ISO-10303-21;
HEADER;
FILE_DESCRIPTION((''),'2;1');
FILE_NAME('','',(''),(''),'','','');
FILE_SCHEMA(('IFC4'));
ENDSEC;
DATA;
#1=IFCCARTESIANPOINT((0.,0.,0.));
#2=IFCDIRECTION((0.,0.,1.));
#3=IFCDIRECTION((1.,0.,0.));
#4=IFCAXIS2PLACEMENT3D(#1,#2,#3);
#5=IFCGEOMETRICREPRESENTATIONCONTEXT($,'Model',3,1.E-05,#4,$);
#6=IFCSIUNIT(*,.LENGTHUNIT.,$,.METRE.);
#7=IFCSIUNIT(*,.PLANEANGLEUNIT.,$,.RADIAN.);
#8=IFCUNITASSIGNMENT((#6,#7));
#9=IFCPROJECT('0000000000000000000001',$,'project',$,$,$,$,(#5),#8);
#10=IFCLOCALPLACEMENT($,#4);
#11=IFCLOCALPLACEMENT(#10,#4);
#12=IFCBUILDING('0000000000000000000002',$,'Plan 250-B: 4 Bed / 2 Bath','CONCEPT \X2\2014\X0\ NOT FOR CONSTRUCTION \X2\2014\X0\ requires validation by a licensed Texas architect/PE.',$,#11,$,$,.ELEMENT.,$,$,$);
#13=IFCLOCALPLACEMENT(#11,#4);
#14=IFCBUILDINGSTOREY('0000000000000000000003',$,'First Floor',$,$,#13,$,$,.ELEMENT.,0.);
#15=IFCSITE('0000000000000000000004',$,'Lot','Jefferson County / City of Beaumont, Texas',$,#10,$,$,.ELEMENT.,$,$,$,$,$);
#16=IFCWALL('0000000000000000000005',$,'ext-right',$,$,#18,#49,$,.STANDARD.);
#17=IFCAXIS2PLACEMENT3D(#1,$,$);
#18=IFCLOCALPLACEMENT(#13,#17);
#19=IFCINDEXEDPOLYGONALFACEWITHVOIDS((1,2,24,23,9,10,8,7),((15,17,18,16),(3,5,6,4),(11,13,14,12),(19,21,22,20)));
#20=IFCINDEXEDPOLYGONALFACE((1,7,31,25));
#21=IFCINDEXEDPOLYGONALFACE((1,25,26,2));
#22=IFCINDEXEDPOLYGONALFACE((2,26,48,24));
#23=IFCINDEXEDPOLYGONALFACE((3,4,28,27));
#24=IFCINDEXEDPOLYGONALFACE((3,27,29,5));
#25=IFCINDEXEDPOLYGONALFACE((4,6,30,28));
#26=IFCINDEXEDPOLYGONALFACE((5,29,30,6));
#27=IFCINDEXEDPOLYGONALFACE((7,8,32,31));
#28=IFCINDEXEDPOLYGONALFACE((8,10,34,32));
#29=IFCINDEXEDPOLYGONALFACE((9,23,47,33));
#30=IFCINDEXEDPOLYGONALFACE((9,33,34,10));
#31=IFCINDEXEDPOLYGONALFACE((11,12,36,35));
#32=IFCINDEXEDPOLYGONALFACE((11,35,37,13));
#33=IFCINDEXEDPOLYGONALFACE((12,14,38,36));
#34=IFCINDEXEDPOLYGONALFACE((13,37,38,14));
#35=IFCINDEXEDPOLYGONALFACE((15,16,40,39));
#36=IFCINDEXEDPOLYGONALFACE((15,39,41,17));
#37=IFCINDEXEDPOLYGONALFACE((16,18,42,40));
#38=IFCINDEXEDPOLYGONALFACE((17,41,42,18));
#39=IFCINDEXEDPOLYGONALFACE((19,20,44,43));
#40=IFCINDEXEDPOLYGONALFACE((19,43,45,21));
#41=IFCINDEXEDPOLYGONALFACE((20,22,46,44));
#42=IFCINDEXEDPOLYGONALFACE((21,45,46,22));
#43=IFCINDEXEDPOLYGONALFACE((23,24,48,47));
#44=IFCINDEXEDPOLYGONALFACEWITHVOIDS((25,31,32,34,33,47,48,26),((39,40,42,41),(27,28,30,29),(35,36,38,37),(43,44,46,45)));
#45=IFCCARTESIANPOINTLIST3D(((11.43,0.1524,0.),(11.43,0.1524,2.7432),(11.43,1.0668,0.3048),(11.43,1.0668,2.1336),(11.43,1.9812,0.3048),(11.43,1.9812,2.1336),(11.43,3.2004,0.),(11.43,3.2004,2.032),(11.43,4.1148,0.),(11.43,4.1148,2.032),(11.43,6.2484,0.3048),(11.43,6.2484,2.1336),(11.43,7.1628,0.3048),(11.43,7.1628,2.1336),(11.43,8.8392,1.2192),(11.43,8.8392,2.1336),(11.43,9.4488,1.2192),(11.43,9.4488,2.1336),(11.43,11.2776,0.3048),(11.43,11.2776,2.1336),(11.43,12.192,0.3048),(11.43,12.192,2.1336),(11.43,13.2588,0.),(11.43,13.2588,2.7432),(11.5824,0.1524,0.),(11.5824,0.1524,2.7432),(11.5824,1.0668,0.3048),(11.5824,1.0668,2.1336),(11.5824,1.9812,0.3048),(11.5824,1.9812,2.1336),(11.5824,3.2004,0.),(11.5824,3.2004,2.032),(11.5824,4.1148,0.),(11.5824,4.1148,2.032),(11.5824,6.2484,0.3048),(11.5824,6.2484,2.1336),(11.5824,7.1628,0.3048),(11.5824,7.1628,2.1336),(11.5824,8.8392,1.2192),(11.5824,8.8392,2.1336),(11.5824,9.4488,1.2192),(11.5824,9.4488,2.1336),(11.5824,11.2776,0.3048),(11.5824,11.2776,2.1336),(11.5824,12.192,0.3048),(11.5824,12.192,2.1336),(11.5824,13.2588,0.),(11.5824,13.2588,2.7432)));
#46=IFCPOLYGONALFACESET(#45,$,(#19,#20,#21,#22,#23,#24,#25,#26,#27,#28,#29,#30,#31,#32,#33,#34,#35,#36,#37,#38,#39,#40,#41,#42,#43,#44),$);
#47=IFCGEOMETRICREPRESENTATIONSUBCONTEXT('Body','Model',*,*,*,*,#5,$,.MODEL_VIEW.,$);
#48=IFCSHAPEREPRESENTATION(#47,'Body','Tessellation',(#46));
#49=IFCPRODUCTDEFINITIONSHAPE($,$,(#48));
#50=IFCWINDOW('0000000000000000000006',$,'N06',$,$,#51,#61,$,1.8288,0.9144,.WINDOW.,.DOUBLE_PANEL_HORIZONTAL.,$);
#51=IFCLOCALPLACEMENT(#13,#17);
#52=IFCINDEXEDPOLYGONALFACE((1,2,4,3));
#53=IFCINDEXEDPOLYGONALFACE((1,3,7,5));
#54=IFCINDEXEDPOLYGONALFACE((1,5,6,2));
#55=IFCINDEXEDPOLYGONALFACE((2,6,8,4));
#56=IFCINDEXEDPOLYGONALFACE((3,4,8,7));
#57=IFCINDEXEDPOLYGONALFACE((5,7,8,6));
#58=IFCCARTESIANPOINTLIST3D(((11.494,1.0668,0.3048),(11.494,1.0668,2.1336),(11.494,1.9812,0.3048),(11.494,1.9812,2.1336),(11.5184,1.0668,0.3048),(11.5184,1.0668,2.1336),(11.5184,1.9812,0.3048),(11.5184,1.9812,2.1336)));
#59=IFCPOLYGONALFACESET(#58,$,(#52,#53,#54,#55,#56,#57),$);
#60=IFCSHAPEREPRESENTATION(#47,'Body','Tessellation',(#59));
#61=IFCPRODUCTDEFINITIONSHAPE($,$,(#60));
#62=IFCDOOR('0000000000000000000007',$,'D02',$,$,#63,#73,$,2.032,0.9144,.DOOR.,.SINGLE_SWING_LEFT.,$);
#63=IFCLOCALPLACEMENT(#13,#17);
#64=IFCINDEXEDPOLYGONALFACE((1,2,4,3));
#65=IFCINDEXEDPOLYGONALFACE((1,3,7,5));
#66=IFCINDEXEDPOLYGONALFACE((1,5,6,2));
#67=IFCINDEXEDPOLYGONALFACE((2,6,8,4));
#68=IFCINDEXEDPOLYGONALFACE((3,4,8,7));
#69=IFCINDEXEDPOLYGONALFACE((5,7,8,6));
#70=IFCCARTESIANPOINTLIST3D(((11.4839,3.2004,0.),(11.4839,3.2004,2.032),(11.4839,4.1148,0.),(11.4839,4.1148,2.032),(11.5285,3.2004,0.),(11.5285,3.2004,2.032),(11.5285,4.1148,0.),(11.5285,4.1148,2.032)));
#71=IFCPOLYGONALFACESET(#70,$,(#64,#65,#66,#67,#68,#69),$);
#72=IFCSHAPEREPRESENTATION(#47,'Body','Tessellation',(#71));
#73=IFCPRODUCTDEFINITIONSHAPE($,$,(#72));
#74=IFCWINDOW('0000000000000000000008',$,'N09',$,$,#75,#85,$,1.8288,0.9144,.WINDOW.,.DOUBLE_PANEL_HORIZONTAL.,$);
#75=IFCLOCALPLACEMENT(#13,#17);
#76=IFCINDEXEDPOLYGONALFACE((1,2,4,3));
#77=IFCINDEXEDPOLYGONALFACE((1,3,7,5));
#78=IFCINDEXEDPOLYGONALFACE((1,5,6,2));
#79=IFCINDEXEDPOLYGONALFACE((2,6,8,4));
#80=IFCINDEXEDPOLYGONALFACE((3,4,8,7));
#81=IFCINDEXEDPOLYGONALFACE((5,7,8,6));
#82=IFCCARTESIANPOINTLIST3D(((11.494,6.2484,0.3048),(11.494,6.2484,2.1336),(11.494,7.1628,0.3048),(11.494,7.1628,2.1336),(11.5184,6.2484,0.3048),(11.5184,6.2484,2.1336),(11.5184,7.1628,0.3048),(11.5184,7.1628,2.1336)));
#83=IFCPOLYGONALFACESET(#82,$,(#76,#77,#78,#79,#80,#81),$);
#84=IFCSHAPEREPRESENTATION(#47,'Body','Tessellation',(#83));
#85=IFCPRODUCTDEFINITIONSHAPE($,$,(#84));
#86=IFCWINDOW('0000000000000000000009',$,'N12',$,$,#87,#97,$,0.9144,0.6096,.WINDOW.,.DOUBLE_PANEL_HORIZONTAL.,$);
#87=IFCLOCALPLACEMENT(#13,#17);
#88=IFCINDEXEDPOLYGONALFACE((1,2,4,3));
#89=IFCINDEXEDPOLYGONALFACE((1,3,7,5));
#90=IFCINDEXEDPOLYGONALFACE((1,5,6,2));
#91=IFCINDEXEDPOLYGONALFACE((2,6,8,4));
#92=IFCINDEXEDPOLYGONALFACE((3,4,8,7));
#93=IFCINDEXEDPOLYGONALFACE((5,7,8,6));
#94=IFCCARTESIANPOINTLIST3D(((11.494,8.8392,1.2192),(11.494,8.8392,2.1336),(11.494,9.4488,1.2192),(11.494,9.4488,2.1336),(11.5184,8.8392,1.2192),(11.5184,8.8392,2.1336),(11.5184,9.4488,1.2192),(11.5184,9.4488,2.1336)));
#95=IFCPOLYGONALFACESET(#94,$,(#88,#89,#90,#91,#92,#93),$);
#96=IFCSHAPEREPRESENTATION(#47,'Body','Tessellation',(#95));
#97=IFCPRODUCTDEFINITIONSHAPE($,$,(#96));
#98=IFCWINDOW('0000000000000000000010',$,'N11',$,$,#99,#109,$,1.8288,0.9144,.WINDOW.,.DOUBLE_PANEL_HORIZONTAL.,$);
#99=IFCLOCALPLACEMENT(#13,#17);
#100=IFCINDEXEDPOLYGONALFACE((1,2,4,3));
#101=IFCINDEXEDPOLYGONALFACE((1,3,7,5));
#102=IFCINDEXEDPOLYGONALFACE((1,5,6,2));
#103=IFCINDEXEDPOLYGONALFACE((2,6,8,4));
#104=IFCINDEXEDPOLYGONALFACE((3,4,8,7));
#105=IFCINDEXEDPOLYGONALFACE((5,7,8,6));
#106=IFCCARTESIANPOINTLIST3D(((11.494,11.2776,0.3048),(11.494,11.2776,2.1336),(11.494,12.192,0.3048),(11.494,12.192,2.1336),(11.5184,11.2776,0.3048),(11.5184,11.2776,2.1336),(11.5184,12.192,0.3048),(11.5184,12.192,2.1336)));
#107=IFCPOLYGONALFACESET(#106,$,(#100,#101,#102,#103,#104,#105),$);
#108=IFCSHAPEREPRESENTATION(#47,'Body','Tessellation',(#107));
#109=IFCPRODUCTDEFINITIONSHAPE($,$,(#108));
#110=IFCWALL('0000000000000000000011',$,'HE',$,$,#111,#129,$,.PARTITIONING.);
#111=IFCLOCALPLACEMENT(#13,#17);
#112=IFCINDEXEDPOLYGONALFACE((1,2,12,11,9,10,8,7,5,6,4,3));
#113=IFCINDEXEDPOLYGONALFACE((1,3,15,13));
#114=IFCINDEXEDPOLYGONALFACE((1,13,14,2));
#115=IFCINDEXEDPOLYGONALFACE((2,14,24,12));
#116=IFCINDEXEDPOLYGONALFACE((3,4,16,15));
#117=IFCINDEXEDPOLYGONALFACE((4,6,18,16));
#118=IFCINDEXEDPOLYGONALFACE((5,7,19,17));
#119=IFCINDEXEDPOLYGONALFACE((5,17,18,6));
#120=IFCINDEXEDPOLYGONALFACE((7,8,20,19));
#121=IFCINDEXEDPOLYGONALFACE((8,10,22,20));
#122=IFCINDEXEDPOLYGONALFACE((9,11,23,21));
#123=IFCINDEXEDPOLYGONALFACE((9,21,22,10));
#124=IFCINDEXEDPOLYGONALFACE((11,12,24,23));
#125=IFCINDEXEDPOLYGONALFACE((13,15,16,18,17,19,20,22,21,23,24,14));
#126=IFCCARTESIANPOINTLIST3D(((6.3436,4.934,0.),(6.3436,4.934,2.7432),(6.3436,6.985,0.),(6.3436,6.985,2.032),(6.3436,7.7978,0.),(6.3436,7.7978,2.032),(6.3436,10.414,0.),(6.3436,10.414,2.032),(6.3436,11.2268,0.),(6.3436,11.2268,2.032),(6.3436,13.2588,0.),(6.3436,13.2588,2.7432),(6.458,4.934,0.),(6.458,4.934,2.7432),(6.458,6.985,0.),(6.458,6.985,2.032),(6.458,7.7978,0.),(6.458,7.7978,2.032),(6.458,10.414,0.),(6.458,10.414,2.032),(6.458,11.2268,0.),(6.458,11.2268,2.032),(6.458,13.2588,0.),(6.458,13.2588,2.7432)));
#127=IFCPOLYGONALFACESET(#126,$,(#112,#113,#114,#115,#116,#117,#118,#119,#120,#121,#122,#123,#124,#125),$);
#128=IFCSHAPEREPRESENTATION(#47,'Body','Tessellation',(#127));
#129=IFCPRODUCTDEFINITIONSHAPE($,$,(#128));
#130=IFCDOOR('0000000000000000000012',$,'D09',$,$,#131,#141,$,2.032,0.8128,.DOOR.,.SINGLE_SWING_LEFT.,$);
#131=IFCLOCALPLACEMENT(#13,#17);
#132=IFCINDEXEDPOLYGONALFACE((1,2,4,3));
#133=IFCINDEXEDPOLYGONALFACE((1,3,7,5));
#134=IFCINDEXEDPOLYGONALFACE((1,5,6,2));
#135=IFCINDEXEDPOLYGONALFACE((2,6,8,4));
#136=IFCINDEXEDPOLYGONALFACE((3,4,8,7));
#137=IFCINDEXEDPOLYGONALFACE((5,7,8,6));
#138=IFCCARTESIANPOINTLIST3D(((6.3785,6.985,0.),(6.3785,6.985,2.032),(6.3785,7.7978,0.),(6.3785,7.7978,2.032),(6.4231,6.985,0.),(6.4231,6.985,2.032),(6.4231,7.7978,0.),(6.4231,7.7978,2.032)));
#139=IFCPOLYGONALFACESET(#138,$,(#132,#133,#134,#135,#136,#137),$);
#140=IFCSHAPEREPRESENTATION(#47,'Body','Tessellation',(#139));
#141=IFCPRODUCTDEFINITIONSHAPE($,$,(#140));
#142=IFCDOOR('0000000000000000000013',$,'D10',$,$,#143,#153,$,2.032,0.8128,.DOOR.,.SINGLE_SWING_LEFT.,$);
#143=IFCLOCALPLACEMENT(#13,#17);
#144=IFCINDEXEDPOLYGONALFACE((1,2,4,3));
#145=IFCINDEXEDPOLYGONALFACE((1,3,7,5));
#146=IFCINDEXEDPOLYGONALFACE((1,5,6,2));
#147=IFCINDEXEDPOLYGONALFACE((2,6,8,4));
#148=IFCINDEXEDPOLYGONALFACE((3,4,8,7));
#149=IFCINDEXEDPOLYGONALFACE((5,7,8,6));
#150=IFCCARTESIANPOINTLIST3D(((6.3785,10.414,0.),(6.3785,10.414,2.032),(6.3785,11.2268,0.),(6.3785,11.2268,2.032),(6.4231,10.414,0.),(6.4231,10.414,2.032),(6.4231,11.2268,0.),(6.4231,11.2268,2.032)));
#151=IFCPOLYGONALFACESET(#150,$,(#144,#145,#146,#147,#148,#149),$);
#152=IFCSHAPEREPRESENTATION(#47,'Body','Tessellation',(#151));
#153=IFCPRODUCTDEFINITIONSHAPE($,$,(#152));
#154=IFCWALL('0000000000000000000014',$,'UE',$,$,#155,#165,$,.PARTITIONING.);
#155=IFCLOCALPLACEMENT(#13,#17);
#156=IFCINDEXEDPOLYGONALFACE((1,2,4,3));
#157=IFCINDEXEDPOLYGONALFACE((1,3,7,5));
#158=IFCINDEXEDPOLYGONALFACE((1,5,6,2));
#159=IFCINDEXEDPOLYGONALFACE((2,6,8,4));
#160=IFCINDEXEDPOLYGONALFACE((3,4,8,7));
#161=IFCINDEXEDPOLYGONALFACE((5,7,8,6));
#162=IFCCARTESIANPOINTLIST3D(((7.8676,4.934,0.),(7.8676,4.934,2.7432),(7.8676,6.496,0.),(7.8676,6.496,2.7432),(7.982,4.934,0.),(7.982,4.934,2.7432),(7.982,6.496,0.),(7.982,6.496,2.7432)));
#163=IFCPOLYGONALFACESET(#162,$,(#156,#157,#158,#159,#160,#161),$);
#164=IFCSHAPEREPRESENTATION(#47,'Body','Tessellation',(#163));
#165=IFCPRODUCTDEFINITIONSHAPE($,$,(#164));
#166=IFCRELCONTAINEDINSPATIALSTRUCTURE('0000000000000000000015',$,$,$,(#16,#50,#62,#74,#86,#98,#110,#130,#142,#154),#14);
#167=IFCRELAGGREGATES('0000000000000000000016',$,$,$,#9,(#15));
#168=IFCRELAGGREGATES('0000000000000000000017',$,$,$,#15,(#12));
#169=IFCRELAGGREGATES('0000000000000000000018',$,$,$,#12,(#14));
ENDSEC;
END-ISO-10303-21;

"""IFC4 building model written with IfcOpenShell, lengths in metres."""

from ifc_helpers import new_model, si_unit, frame, frame_2d, origin_with_axes, place, context, subcontext, project, spatial, rectangle, extrude, element, fill, save


model = new_model("IFC4")

# Units and contexts
model_context = context("Model", 3, precision=1e-05, world=origin_with_axes())
body_context = subcontext(model_context, "Body", "Model", "MODEL_VIEW")
ifc_project = project(units=[si_unit("LENGTHUNIT", "METRE"), si_unit("PLANEANGLEUNIT", "RADIAN")], contexts=[model_context])

# Site, building, storey
site_placement = place(None, origin_with_axes())
site = spatial("IfcSite", under=ifc_project, at=site_placement, Name="Lot", Description="Jefferson County / City of Beaumont, Texas", CompositionType="ELEMENT")
building_placement = place(site_placement, origin_with_axes())
building = spatial("IfcBuilding", under=site, at=building_placement, Name="Plan 250-B: 4 Bed / 2 Bath", Description="CONCEPT — NOT FOR CONSTRUCTION — requires validation by a licensed Texas architect/PE.", CompositionType="ELEMENT")
storey_placement = place(building_placement, origin_with_axes())
storey = spatial("IfcBuildingStorey", under=building, at=storey_placement, Name="First Floor", CompositionType="ELEMENT", Elevation=0.0)

# Wall, openings, windows, door
wall_1_placement = place(storey_placement, frame((11.5062, 0.1524, 0.0), z_axis=(0.0, 0.0, 1.0), x_axis=(0.0, 1.0, 0.0)))
wall_1 = element("IfcWall", 1, at=wall_1_placement, inside=storey, Name="ext-right", PredefinedType="STANDARD", context=body_context, shape_type="SweptSolid", body=[
    extrude(rectangle(XDim=13.1064, YDim=0.1524, at=frame_2d((6.5532, 0.0), x_axis=(1.0, 0.0))), origin_with_axes(), (0.0, 0.0, 1.0), 2.7432),
])
opening_1_placement = place(wall_1_placement, frame((0.9144, 0.0, 0.3048), z_axis=(0.0, 0.0, 1.0), x_axis=(1.0, 0.0, 0.0)))
opening_1 = element("IfcOpeningElement", 2, at=opening_1_placement, cuts=wall_1, PredefinedType="OPENING", context=body_context, shape_type="SweptSolid", body=[
    extrude(rectangle(XDim=0.9144, YDim=0.1829, at=frame_2d((0.4572, 0.0), x_axis=(1.0, 0.0))), origin_with_axes(), (0.0, 0.0, 1.0), 1.8288),
])
opening_2_placement = place(wall_1_placement, frame((3.048, 0.0, 0.0), z_axis=(0.0, 0.0, 1.0), x_axis=(1.0, 0.0, 0.0)))
opening_2 = element("IfcOpeningElement", 3, at=opening_2_placement, cuts=wall_1, PredefinedType="OPENING", context=body_context, shape_type="SweptSolid", body=[
    extrude(rectangle(XDim=0.9144, YDim=0.1829, at=frame_2d((0.4572, 0.0), x_axis=(1.0, 0.0))), origin_with_axes(), (0.0, 0.0, 1.0), 2.032),
])
opening_3_placement = place(wall_1_placement, frame((6.096, 0.0, 0.3048), z_axis=(0.0, 0.0, 1.0), x_axis=(1.0, 0.0, 0.0)))
opening_3 = element("IfcOpeningElement", 4, at=opening_3_placement, cuts=wall_1, PredefinedType="OPENING", context=body_context, shape_type="SweptSolid", body=[
    extrude(rectangle(XDim=0.9144, YDim=0.1829, at=frame_2d((0.4572, 0.0), x_axis=(1.0, 0.0))), origin_with_axes(), (0.0, 0.0, 1.0), 1.8288),
])
opening_4_placement = place(wall_1_placement, frame((8.6868, 0.0, 1.2192), z_axis=(0.0, 0.0, 1.0), x_axis=(1.0, 0.0, 0.0)))
opening_4 = element("IfcOpeningElement", 5, at=opening_4_placement, cuts=wall_1, PredefinedType="OPENING", context=body_context, shape_type="SweptSolid", body=[
    extrude(rectangle(XDim=0.6096, YDim=0.1829, at=frame_2d((0.3048, 0.0), x_axis=(1.0, 0.0))), origin_with_axes(), (0.0, 0.0, 1.0), 0.9144),
])
opening_5_placement = place(wall_1_placement, frame((11.1252, 0.0, 0.3048), z_axis=(0.0, 0.0, 1.0), x_axis=(1.0, 0.0, 0.0)))
opening_5 = element("IfcOpeningElement", 6, at=opening_5_placement, cuts=wall_1, PredefinedType="OPENING", context=body_context, shape_type="SweptSolid", body=[
    extrude(rectangle(XDim=0.9144, YDim=0.1829, at=frame_2d((0.4572, 0.0), x_axis=(1.0, 0.0))), origin_with_axes(), (0.0, 0.0, 1.0), 1.8288),
])
window_1_placement = place(opening_1_placement, origin_with_axes())
window_1 = element("IfcWindow", 7, at=window_1_placement, inside=storey, Name="N06", OverallHeight=1.8288, OverallWidth=0.9144, PartitioningType="DOUBLE_PANEL_HORIZONTAL", PredefinedType="WINDOW", context=body_context, shape_type="SweptSolid", body=[
    extrude(rectangle(XDim=0.9144, YDim=0.0244, at=frame_2d((0.4572, 0.0), x_axis=(1.0, 0.0))), origin_with_axes(), (0.0, 0.0, 1.0), 1.8288),
])
fill(opening_1, window_1)
door_1_placement = place(opening_2_placement, origin_with_axes())
door_1 = element("IfcDoor", 8, at=door_1_placement, inside=storey, Name="D02", OperationType="SINGLE_SWING_LEFT", OverallHeight=2.032, OverallWidth=0.9144, PredefinedType="DOOR", context=body_context, shape_type="SweptSolid", body=[
    extrude(rectangle(XDim=0.9144, YDim=0.0445, at=frame_2d((0.4572, 0.0), x_axis=(1.0, 0.0))), origin_with_axes(), (0.0, 0.0, 1.0), 2.032),
])
fill(opening_2, door_1)
window_2_placement = place(opening_3_placement, origin_with_axes())
window_2 = element("IfcWindow", 9, at=window_2_placement, inside=storey, Name="N09", OverallHeight=1.8288, OverallWidth=0.9144, PartitioningType="DOUBLE_PANEL_HORIZONTAL", PredefinedType="WINDOW", context=body_context, shape_type="SweptSolid", body=[
    extrude(rectangle(XDim=0.9144, YDim=0.0244, at=frame_2d((0.4572, 0.0), x_axis=(1.0, 0.0))), origin_with_axes(), (0.0, 0.0, 1.0), 1.8288),
])
fill(opening_3, window_2)
window_3_placement = place(opening_4_placement, origin_with_axes())
window_3 = element("IfcWindow", 10, at=window_3_placement, inside=storey, Name="N12", OverallHeight=0.9144, OverallWidth=0.6096, PartitioningType="DOUBLE_PANEL_HORIZONTAL", PredefinedType="WINDOW", context=body_context, shape_type="SweptSolid", body=[
    extrude(rectangle(XDim=0.6096, YDim=0.0244, at=frame_2d((0.3048, 0.0), x_axis=(1.0, 0.0))), origin_with_axes(), (0.0, 0.0, 1.0), 0.9144),
])
fill(opening_4, window_3)
window_4_placement = place(opening_5_placement, origin_with_axes())
window_4 = element("IfcWindow", 11, at=window_4_placement, inside=storey, Name="N11", OverallHeight=1.8288, OverallWidth=0.9144, PartitioningType="DOUBLE_PANEL_HORIZONTAL", PredefinedType="WINDOW", context=body_context, shape_type="SweptSolid", body=[
    extrude(rectangle(XDim=0.9144, YDim=0.0244, at=frame_2d((0.4572, 0.0), x_axis=(1.0, 0.0))), origin_with_axes(), (0.0, 0.0, 1.0), 1.8288),
])
fill(opening_5, window_4)

# Wall, openings, doors
wall_2_placement = place(storey_placement, frame((6.4008, 4.934, 0.0), z_axis=(0.0, 0.0, 1.0), x_axis=(0.0, 1.0, 0.0)))
wall_2 = element("IfcWall", 12, at=wall_2_placement, inside=storey, Name="HE", PredefinedType="PARTITIONING", context=body_context, shape_type="SweptSolid", body=[
    extrude(rectangle(XDim=8.3248, YDim=0.1143, at=frame_2d((4.1624, 0.0), x_axis=(1.0, 0.0))), origin_with_axes(), (0.0, 0.0, 1.0), 2.7432),
])
opening_6_placement = place(wall_2_placement, frame((2.051, 0.0, 0.0), z_axis=(0.0, 0.0, 1.0), x_axis=(1.0, 0.0, 0.0)))
opening_6 = element("IfcOpeningElement", 13, at=opening_6_placement, cuts=wall_2, PredefinedType="OPENING", context=body_context, shape_type="SweptSolid", body=[
    extrude(rectangle(XDim=0.8128, YDim=0.1448, at=frame_2d((0.4064, 0.0), x_axis=(1.0, 0.0))), origin_with_axes(), (0.0, 0.0, 1.0), 2.032),
])
opening_7_placement = place(wall_2_placement, frame((5.48, 0.0, 0.0), z_axis=(0.0, 0.0, 1.0), x_axis=(1.0, 0.0, 0.0)))
opening_7 = element("IfcOpeningElement", 14, at=opening_7_placement, cuts=wall_2, PredefinedType="OPENING", context=body_context, shape_type="SweptSolid", body=[
    extrude(rectangle(XDim=0.8128, YDim=0.1448, at=frame_2d((0.4064, 0.0), x_axis=(1.0, 0.0))), origin_with_axes(), (0.0, 0.0, 1.0), 2.032),
])
door_2_placement = place(opening_6_placement, origin_with_axes())
door_2 = element("IfcDoor", 15, at=door_2_placement, inside=storey, Name="D09", OperationType="SINGLE_SWING_LEFT", OverallHeight=2.032, OverallWidth=0.8128, PredefinedType="DOOR", context=body_context, shape_type="SweptSolid", body=[
    extrude(rectangle(XDim=0.8128, YDim=0.0445, at=frame_2d((0.4064, 0.0), x_axis=(1.0, 0.0))), origin_with_axes(), (0.0, 0.0, 1.0), 2.032),
])
fill(opening_6, door_2)
door_3_placement = place(opening_7_placement, origin_with_axes())
door_3 = element("IfcDoor", 16, at=door_3_placement, inside=storey, Name="D10", OperationType="SINGLE_SWING_LEFT", OverallHeight=2.032, OverallWidth=0.8128, PredefinedType="DOOR", context=body_context, shape_type="SweptSolid", body=[
    extrude(rectangle(XDim=0.8128, YDim=0.0445, at=frame_2d((0.4064, 0.0), x_axis=(1.0, 0.0))), origin_with_axes(), (0.0, 0.0, 1.0), 2.032),
])
fill(opening_7, door_3)

# Wall
wall_3_placement = place(storey_placement, frame((7.9248, 4.934, 0.0), z_axis=(0.0, 0.0, 1.0), x_axis=(0.0, 1.0, 0.0)))
element("IfcWall", 17, at=wall_3_placement, inside=storey, Name="UE", PredefinedType="PARTITIONING", context=body_context, shape_type="SweptSolid", body=[
    extrude(rectangle(XDim=1.5621, YDim=0.1143, at=frame_2d((0.7811, 0.0), x_axis=(1.0, 0.0))), origin_with_axes(), (0.0, 0.0, 1.0), 2.7432),
])

save(model, "model.ifc")
